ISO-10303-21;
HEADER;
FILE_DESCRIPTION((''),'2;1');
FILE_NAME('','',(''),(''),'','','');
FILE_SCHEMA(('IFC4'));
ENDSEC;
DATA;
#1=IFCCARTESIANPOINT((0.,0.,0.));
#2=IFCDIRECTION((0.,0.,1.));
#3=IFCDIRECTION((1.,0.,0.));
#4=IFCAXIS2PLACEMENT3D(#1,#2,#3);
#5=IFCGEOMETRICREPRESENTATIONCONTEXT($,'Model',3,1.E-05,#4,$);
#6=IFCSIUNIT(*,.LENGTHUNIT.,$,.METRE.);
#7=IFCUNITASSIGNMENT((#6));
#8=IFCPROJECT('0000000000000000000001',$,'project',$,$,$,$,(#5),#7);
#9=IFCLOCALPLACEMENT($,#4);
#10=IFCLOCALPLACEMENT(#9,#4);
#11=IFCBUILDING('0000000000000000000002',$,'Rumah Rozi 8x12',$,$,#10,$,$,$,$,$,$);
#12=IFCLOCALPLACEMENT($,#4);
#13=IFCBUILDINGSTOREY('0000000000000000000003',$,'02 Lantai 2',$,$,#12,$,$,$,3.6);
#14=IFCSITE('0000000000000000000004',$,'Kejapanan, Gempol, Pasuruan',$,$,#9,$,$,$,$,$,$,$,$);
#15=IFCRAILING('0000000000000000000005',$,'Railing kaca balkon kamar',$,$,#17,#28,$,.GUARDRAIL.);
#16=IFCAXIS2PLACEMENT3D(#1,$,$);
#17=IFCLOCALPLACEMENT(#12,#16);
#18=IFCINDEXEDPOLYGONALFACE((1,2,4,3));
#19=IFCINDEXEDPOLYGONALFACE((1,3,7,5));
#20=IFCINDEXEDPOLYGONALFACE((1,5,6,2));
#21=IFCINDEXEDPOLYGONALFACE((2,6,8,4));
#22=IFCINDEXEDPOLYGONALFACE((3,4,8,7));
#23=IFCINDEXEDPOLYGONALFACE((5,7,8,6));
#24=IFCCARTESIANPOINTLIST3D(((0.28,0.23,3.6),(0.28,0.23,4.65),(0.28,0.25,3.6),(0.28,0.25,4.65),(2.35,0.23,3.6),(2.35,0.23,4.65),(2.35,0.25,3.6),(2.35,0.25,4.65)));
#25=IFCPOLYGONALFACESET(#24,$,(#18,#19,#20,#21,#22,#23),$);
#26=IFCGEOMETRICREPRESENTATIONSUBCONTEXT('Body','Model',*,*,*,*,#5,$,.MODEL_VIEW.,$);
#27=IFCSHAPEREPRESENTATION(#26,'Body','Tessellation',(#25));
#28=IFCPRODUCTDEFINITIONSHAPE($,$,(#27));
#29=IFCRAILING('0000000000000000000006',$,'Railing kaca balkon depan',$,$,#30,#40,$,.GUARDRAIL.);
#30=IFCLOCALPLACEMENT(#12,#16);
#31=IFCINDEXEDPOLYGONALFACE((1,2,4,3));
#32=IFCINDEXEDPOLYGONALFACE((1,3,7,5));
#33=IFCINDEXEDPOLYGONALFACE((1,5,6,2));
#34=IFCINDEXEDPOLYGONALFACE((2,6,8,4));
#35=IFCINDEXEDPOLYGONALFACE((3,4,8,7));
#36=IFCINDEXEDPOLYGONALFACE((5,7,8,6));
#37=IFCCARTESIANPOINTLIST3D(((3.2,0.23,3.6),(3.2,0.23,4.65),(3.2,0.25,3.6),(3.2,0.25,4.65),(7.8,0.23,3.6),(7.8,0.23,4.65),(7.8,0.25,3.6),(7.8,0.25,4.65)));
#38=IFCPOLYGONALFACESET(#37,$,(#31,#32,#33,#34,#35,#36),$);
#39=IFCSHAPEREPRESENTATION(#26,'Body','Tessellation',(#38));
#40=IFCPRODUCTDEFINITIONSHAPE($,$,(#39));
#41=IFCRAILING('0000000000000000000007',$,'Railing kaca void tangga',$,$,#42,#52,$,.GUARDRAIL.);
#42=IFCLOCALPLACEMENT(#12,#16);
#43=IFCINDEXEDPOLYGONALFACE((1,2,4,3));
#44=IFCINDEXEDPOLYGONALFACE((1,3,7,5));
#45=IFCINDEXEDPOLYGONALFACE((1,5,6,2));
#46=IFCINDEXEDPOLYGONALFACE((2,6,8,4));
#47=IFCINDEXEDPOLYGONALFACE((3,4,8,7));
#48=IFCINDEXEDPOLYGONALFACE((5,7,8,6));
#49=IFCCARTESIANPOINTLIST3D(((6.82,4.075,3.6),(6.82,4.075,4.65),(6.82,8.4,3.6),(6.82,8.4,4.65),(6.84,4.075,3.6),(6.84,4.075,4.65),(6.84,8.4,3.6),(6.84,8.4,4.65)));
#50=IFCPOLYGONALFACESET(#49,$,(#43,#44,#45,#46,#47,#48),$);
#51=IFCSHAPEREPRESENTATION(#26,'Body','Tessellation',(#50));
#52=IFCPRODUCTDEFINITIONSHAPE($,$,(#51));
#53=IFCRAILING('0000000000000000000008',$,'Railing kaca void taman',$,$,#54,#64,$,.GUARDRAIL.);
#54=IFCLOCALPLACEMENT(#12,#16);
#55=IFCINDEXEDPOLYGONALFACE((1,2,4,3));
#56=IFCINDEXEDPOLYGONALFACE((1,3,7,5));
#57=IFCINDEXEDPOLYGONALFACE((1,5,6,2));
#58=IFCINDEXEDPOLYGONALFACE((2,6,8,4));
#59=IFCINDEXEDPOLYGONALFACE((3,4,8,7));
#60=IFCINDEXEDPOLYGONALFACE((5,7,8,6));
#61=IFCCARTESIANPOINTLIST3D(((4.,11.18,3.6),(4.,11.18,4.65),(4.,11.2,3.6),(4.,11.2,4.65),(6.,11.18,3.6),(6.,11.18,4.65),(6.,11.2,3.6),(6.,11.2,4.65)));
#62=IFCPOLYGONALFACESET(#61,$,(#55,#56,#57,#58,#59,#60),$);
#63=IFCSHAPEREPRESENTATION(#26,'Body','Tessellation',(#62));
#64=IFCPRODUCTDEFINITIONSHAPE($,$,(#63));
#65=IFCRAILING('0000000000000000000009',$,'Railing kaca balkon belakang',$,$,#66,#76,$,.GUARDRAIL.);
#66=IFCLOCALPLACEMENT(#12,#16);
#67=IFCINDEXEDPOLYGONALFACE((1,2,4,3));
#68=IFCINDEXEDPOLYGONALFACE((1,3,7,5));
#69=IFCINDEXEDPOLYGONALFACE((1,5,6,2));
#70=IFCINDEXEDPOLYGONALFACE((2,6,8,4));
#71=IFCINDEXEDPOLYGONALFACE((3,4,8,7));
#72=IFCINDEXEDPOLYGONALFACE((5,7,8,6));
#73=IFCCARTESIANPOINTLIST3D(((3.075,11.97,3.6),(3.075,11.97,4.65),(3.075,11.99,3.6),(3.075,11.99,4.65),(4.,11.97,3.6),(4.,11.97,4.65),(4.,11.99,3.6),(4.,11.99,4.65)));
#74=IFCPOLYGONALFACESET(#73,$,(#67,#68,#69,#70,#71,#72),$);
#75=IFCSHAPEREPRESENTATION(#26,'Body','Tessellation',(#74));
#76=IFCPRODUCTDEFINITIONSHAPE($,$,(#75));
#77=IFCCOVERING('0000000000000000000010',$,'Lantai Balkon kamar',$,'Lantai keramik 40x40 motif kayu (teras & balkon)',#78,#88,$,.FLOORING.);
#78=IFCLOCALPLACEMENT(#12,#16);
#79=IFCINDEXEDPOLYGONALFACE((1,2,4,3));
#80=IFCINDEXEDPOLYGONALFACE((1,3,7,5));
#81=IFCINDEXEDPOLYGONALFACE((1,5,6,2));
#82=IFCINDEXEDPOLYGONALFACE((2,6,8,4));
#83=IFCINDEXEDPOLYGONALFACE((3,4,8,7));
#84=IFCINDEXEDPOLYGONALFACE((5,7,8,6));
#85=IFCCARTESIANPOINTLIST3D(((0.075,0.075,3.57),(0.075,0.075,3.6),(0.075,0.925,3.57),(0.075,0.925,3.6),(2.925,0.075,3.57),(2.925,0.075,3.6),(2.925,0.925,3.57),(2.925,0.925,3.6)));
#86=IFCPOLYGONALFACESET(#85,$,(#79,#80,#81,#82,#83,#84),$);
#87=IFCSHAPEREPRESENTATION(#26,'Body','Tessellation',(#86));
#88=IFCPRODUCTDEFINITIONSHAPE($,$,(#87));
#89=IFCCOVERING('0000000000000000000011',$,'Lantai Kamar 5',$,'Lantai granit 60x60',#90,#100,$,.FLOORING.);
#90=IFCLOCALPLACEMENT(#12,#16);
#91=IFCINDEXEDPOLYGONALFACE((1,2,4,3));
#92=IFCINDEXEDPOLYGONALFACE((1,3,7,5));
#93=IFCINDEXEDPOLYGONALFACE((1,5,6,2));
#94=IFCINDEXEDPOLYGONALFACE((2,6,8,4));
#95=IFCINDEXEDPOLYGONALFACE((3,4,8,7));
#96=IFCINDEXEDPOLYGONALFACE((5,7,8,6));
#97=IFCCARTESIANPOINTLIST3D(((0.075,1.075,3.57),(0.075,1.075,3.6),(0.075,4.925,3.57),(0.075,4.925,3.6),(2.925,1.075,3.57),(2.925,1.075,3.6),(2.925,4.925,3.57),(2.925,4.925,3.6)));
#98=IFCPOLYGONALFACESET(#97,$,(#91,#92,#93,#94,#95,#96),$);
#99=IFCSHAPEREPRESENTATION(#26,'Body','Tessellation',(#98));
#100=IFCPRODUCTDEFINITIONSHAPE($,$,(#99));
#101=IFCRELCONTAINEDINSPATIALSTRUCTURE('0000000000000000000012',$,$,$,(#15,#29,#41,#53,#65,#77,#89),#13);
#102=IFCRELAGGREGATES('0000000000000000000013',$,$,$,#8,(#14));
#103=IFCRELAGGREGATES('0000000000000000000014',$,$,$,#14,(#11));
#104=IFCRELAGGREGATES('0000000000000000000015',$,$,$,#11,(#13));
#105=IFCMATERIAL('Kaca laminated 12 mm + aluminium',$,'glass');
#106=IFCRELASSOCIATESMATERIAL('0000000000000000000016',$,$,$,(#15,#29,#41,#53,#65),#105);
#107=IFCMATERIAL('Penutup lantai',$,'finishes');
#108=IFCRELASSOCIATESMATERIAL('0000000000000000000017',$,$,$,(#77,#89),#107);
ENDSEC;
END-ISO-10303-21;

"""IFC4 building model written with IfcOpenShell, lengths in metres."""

from ifc_helpers import new_model, si_unit, frame, origin_with_axes, place, context, subcontext, project, spatial, line, indexed_curve, outline, extrude, material, element, save


model = new_model("IFC4")

# Units and contexts
model_context = context("Model", 3, precision=1e-05, world=origin_with_axes())
body_context = subcontext(model_context, "Body", "Model", "MODEL_VIEW")
ifc_project = project(units=[si_unit("LENGTHUNIT", "METRE")], contexts=[model_context])

# Site, building, storey
site_placement = place(None, origin_with_axes())
site = spatial("IfcSite", under=ifc_project, at=site_placement, Name="Kejapanan, Gempol, Pasuruan")
building_placement = place(site_placement, origin_with_axes())
building = spatial("IfcBuilding", under=site, at=building_placement, Name="Rumah Rozi 8x12")
storey_placement = place(None, origin_with_axes())
storey = spatial("IfcBuildingStorey", under=building, at=storey_placement, Name="02 Lantai 2", Elevation=3.6)

# Railings
ifc_material_1 = material(Name="Kaca laminated 12 mm + aluminium", Category="glass")
railing_1_placement = place(storey_placement, origin_with_axes())
element("IfcRailing", 1, at=railing_1_placement, inside=storey, material=ifc_material_1, Name="Railing kaca balkon kamar", PredefinedType="GUARDRAIL", context=body_context, shape_type="SweptSolid", body=[
    extrude(outline(indexed_curve([(0.28, 0.23), (2.35, 0.23), (2.35, 0.25), (0.28, 0.25)], segments=[line(1, 2, 3, 4, 1)])), frame((0.0, 0.0, 3.6), z_axis=(0.0, 0.0, 1.0), x_axis=(1.0, 0.0, 0.0)), (0.0, 0.0, 1.0), 1.05),
])
railing_2_placement = place(storey_placement, origin_with_axes())
element("IfcRailing", 2, at=railing_2_placement, inside=storey, material=ifc_material_1, Name="Railing kaca balkon depan", PredefinedType="GUARDRAIL", context=body_context, shape_type="SweptSolid", body=[
    extrude(outline(indexed_curve([(3.2, 0.23), (7.8, 0.23), (7.8, 0.25), (3.2, 0.25)], segments=[line(1, 2, 3, 4, 1)])), frame((0.0, 0.0, 3.6), z_axis=(0.0, 0.0, 1.0), x_axis=(1.0, 0.0, 0.0)), (0.0, 0.0, 1.0), 1.05),
])
railing_3_placement = place(storey_placement, origin_with_axes())
element("IfcRailing", 3, at=railing_3_placement, inside=storey, material=ifc_material_1, Name="Railing kaca void tangga", PredefinedType="GUARDRAIL", context=body_context, shape_type="SweptSolid", body=[
    extrude(outline(indexed_curve([(6.82, 4.075), (6.84, 4.075), (6.84, 8.4), (6.82, 8.4)], segments=[line(1, 2, 3, 4, 1)])), frame((0.0, 0.0, 3.6), z_axis=(0.0, 0.0, 1.0), x_axis=(1.0, 0.0, 0.0)), (0.0, 0.0, 1.0), 1.05),
])
railing_4_placement = place(storey_placement, origin_with_axes())
element("IfcRailing", 4, at=railing_4_placement, inside=storey, material=ifc_material_1, Name="Railing kaca void taman", PredefinedType="GUARDRAIL", context=body_context, shape_type="SweptSolid", body=[
    extrude(outline(indexed_curve([(4.0, 11.18), (6.0, 11.18), (6.0, 11.2), (4.0, 11.2)], segments=[line(1, 2, 3, 4, 1)])), frame((0.0, 0.0, 3.6), z_axis=(0.0, 0.0, 1.0), x_axis=(1.0, 0.0, 0.0)), (0.0, 0.0, 1.0), 1.05),
])
railing_5_placement = place(storey_placement, origin_with_axes())
element("IfcRailing", 5, at=railing_5_placement, inside=storey, material=ifc_material_1, Name="Railing kaca balkon belakang", PredefinedType="GUARDRAIL", context=body_context, shape_type="SweptSolid", body=[
    extrude(outline(indexed_curve([(3.075, 11.97), (4.0, 11.97), (4.0, 11.99), (3.075, 11.99)], segments=[line(1, 2, 3, 4, 1)])), frame((0.0, 0.0, 3.6), z_axis=(0.0, 0.0, 1.0), x_axis=(1.0, 0.0, 0.0)), (0.0, 0.0, 1.0), 1.05),
])

# Coverings
ifc_material_2 = material(Name="Penutup lantai", Category="finishes")
covering_1_placement = place(storey_placement, origin_with_axes())
element("IfcCovering", 6, at=covering_1_placement, inside=storey, material=ifc_material_2, Name="Lantai Balkon kamar", ObjectType="Lantai keramik 40x40 motif kayu (teras & balkon)", PredefinedType="FLOORING", context=body_context, shape_type="SweptSolid", body=[
    extrude(outline(indexed_curve([(0.075, 0.075), (2.925, 0.075), (2.925, 0.925), (0.075, 0.925)], segments=[line(1, 2, 3, 4, 1)])), frame((0.0, 0.0, 3.57), z_axis=(0.0, 0.0, 1.0), x_axis=(1.0, 0.0, 0.0)), (0.0, 0.0, 1.0), 0.03),
])
covering_2_placement = place(storey_placement, origin_with_axes())
element("IfcCovering", 7, at=covering_2_placement, inside=storey, material=ifc_material_2, Name="Lantai Kamar 5", ObjectType="Lantai granit 60x60", PredefinedType="FLOORING", context=body_context, shape_type="SweptSolid", body=[
    extrude(outline(indexed_curve([(0.075, 1.075), (2.925, 1.075), (2.925, 4.925), (0.075, 4.925)], segments=[line(1, 2, 3, 4, 1)])), frame((0.0, 0.0, 3.57), z_axis=(0.0, 0.0, 1.0), x_axis=(1.0, 0.0, 0.0)), (0.0, 0.0, 1.0), 0.03),
])

save(model, "model.ifc")
